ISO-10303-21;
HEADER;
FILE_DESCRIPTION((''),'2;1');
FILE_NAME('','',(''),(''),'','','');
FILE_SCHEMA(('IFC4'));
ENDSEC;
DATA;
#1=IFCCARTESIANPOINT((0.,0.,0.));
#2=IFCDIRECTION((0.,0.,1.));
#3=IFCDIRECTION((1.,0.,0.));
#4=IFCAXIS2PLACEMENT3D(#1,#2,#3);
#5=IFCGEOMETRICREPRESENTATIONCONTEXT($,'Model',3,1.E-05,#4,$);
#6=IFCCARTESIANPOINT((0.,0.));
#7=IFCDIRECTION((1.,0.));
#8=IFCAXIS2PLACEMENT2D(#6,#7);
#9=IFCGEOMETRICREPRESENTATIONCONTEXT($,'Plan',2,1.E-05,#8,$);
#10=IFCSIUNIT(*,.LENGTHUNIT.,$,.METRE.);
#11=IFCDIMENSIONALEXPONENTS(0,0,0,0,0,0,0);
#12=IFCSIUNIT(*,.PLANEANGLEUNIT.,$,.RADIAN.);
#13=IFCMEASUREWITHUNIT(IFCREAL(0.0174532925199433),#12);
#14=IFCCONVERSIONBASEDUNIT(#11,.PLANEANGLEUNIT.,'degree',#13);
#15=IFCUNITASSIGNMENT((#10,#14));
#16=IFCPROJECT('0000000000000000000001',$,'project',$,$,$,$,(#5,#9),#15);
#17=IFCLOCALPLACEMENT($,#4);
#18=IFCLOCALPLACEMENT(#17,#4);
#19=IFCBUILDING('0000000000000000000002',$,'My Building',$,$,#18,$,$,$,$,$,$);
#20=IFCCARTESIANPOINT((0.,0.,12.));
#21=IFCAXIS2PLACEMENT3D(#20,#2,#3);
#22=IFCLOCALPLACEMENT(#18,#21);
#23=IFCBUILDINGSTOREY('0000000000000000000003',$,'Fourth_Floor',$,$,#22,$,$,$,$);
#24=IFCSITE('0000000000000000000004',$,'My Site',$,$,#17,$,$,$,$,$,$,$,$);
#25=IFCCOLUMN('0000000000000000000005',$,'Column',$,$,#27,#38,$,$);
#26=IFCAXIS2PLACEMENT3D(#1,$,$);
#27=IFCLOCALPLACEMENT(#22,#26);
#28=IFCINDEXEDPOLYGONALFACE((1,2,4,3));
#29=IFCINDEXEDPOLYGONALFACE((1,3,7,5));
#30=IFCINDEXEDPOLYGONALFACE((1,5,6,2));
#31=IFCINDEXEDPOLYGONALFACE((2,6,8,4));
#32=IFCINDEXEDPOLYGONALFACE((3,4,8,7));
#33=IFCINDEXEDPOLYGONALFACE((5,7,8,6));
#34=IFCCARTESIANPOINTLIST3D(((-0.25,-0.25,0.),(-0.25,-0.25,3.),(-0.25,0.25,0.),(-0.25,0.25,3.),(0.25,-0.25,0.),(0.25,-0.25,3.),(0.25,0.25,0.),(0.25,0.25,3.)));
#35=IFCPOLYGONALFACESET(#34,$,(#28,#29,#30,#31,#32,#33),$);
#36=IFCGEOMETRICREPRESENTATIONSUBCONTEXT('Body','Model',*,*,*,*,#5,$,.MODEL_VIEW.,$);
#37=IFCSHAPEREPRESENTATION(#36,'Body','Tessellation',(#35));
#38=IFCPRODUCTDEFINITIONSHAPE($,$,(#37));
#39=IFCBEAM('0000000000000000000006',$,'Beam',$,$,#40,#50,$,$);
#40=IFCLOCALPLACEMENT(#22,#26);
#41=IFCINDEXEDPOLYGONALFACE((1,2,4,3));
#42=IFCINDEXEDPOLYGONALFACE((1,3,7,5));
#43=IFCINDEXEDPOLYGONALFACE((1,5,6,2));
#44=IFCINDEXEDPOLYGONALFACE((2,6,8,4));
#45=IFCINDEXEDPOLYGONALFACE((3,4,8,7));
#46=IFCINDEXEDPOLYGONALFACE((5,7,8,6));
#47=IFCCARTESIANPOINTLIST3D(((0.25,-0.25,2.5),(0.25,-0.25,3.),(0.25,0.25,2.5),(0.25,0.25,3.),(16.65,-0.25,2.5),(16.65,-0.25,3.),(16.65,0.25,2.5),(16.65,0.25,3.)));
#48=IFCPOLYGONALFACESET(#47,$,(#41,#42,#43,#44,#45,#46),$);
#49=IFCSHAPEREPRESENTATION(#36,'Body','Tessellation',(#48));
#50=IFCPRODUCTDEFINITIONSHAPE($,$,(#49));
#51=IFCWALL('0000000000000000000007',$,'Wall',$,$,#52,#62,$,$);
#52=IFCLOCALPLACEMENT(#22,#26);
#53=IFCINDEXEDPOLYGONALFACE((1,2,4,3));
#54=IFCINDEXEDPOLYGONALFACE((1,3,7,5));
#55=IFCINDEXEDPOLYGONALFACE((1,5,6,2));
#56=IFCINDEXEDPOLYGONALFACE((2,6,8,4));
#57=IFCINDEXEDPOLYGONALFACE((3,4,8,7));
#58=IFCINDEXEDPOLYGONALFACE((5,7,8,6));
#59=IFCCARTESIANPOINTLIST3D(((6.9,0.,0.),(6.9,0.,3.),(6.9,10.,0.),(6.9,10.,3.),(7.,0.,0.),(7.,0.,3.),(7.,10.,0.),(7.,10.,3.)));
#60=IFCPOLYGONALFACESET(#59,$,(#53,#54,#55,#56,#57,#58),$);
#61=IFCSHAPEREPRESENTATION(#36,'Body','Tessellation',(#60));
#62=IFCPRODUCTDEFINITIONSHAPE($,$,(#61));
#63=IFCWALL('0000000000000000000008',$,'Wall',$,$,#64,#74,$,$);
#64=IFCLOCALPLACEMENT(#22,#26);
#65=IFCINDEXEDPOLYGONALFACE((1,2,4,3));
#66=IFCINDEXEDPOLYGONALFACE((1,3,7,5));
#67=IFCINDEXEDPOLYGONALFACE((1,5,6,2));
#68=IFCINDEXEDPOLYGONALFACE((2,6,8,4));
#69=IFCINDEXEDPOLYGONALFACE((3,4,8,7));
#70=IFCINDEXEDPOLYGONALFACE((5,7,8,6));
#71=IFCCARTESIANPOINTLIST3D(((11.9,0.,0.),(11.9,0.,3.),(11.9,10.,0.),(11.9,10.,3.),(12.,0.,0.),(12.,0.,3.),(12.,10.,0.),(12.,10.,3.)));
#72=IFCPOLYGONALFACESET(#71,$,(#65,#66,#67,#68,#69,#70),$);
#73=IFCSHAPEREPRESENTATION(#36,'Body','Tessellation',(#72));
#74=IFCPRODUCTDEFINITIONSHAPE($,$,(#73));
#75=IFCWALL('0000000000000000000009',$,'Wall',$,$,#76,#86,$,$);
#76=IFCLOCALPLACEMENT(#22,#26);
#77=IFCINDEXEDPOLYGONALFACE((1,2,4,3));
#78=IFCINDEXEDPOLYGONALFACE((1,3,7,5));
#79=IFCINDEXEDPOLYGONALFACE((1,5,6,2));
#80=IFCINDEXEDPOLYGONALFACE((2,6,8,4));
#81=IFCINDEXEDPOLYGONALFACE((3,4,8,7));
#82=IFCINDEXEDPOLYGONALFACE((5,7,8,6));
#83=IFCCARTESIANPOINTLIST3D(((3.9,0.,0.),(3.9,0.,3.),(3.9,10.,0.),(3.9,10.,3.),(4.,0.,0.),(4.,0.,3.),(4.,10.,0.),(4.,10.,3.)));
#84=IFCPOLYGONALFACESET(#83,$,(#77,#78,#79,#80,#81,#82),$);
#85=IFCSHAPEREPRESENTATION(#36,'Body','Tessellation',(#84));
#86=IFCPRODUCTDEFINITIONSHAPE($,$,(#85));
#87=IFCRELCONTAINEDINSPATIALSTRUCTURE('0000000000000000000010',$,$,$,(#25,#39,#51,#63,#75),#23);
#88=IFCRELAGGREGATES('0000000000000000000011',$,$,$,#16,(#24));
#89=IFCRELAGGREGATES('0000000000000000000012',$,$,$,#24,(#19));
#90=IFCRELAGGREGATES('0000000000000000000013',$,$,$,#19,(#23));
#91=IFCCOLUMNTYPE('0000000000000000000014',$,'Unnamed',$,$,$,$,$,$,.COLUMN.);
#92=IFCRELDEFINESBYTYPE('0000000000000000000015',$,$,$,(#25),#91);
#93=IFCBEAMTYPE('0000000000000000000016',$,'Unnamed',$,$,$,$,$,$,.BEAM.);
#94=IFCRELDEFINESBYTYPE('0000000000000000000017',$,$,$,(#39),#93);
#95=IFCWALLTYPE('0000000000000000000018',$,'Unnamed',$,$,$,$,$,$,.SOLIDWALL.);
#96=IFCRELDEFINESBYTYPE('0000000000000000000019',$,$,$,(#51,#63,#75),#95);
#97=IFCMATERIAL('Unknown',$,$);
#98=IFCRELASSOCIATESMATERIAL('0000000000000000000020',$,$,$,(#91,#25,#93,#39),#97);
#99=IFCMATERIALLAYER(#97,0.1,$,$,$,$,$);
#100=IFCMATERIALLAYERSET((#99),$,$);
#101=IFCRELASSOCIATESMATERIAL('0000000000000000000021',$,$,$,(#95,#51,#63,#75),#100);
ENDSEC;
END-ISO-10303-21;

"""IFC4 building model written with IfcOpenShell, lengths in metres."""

from ifc_helpers import new_model, entity, si_unit, converted_unit, frame, origin_with_axes, origin_2d_with_axis, place, context, subcontext, project, spatial, line, indexed_curve, rectangle, outline, extrude, material, layer, layer_set, layer_usage, material_profile, profile_set, profile_usage, type_object, element, save


model = new_model("IFC4")

# Units and contexts
model_context = context("Model", 3, precision=1e-05, world=origin_with_axes())
plan_context = context("Plan", 2, precision=1e-05, world=origin_2d_with_axis())
body_context_1 = subcontext(model_context, "Body", "Model", "MODEL_VIEW")
ifc_project = project(units=[si_unit("LENGTHUNIT", "METRE"), converted_unit("PLANEANGLEUNIT", "degree", entity("IfcReal", 0.0174532925199433), si_unit("PLANEANGLEUNIT", "RADIAN"), dimensions=[0, 0, 0, 0, 0, 0, 0])], contexts=[model_context, plan_context])

# Site, building, storey
site_placement = place(None, origin_with_axes())
site = spatial("IfcSite", under=ifc_project, at=site_placement, Name="My Site")
building_placement = place(site_placement, origin_with_axes())
building = spatial("IfcBuilding", under=site, at=building_placement, Name="My Building")
storey_placement = place(building_placement, frame((0.0, 0.0, 12.0), z_axis=(0.0, 0.0, 1.0), x_axis=(1.0, 0.0, 0.0)))
storey = spatial("IfcBuildingStorey", under=building, at=storey_placement, Name="Fourth_Floor")

# Column
ifc_material = material(Name="Unknown")
ifc_material_profile_1 = material_profile(ifc_material, rectangle(XDim=0.5, YDim=0.5))
ifc_profile_set_1 = profile_set([ifc_material_profile_1])
ifc_profile_usage_1 = profile_usage(ifc_profile_set_1, cardinal=5)
column_type = type_object("IfcColumnType", Name="Unnamed", PredefinedType="COLUMN", material=ifc_profile_set_1)
column_placement = place(storey_placement, frame((0.0, 0.0, 0.0), z_axis=(0.0, 0.0, 1.0), x_axis=(1.0, 0.0, 0.0)))
element("IfcColumn", 1, at=column_placement, inside=storey, type_object=column_type, material=ifc_profile_usage_1, Name="Column", context=body_context_1, shape_type="SweptSolid", body=[
    extrude(rectangle(XDim=0.5, YDim=0.5), origin_with_axes(), (0.0, 0.0, 1.0), 3.0),
])

# Beam
ifc_material_profile_2 = material_profile(ifc_material, rectangle(XDim=0.5, YDim=0.5))
ifc_profile_set_2 = profile_set([ifc_material_profile_2])
ifc_profile_usage_2 = profile_usage(ifc_profile_set_2, cardinal=6)
beam_type = type_object("IfcBeamType", Name="Unnamed", PredefinedType="BEAM", material=ifc_profile_set_2)
beam_placement = place(storey_placement, frame((0.25, -0.25, 2.75), z_axis=(1.0, 0.0, 0.0), x_axis=(0.0, 1.0, 0.0)))
element("IfcBeam", 2, at=beam_placement, inside=storey, type_object=beam_type, material=ifc_profile_usage_2, Name="Beam", context=body_context_1, shape_type="SweptSolid", body=[
    extrude(rectangle(XDim=0.5, YDim=0.5), frame((0.25, 0.0, 0.0), z_axis=(0.0, 0.0, 1.0), x_axis=(1.0, 0.0, 0.0)), (0.0, 0.0, 1.0), 16.4),
])

# Walls
ifc_layer = layer(ifc_material, 0.1)
ifc_layer_set = layer_set([ifc_layer])
ifc_layer_usage_1 = layer_usage(ifc_layer_set, "AXIS2", "POSITIVE", 0.0)
wall_type = type_object("IfcWallType", Name="Unnamed", PredefinedType="SOLIDWALL", material=ifc_layer_set)
wall_1_placement = place(storey_placement, frame((6.9, 10.0, 0.0), z_axis=(0.0, 0.0, 1.0), x_axis=(0.0, -1.0, 0.0)))
element("IfcWall", 3, at=wall_1_placement, inside=storey, type_object=wall_type, material=ifc_layer_usage_1, Name="Wall", context=body_context_1, shape_type="SweptSolid", body=[
    extrude(outline(indexed_curve([(0.0, 0.0), (0.0, 0.1), (10.0, 0.1), (10.0, 0.0)], segments=[line(1, 2, 3, 4, 1)])), origin_with_axes(), (0.0, 0.0, 1.0), 3.0),
])
ifc_layer_usage_2 = layer_usage(ifc_layer_set, "AXIS2", "POSITIVE", 0.0)
wall_2_placement = place(storey_placement, frame((11.9, 10.0, 0.0), z_axis=(0.0, 0.0, 1.0), x_axis=(0.0, -1.0, 0.0)))
element("IfcWall", 4, at=wall_2_placement, inside=storey, type_object=wall_type, material=ifc_layer_usage_2, Name="Wall", context=body_context_1, shape_type="SweptSolid", body=[
    extrude(outline(indexed_curve([(0.0, 0.0), (0.0, 0.1), (10.0, 0.1), (10.0, 0.0)], segments=[line(1, 2, 3, 4, 1)])), origin_with_axes(), (0.0, 0.0, 1.0), 3.0),
])
ifc_layer_usage_3 = layer_usage(ifc_layer_set, "AXIS2", "POSITIVE", 0.0)
wall_3_placement = place(storey_placement, frame((3.9, 10.0, 0.0), z_axis=(0.0, 0.0, 1.0), x_axis=(0.0, -1.0, 0.0)))
element("IfcWall", 5, at=wall_3_placement, inside=storey, type_object=wall_type, material=ifc_layer_usage_3, Name="Wall", context=body_context_1, shape_type="SweptSolid", body=[
    extrude(outline(indexed_curve([(0.0, 0.0), (0.0, 0.1), (10.0, 0.1), (10.0, 0.0)], segments=[line(1, 2, 3, 4, 1)])), origin_with_axes(), (0.0, 0.0, 1.0), 3.0),
])

save(model, "model.ifc")
